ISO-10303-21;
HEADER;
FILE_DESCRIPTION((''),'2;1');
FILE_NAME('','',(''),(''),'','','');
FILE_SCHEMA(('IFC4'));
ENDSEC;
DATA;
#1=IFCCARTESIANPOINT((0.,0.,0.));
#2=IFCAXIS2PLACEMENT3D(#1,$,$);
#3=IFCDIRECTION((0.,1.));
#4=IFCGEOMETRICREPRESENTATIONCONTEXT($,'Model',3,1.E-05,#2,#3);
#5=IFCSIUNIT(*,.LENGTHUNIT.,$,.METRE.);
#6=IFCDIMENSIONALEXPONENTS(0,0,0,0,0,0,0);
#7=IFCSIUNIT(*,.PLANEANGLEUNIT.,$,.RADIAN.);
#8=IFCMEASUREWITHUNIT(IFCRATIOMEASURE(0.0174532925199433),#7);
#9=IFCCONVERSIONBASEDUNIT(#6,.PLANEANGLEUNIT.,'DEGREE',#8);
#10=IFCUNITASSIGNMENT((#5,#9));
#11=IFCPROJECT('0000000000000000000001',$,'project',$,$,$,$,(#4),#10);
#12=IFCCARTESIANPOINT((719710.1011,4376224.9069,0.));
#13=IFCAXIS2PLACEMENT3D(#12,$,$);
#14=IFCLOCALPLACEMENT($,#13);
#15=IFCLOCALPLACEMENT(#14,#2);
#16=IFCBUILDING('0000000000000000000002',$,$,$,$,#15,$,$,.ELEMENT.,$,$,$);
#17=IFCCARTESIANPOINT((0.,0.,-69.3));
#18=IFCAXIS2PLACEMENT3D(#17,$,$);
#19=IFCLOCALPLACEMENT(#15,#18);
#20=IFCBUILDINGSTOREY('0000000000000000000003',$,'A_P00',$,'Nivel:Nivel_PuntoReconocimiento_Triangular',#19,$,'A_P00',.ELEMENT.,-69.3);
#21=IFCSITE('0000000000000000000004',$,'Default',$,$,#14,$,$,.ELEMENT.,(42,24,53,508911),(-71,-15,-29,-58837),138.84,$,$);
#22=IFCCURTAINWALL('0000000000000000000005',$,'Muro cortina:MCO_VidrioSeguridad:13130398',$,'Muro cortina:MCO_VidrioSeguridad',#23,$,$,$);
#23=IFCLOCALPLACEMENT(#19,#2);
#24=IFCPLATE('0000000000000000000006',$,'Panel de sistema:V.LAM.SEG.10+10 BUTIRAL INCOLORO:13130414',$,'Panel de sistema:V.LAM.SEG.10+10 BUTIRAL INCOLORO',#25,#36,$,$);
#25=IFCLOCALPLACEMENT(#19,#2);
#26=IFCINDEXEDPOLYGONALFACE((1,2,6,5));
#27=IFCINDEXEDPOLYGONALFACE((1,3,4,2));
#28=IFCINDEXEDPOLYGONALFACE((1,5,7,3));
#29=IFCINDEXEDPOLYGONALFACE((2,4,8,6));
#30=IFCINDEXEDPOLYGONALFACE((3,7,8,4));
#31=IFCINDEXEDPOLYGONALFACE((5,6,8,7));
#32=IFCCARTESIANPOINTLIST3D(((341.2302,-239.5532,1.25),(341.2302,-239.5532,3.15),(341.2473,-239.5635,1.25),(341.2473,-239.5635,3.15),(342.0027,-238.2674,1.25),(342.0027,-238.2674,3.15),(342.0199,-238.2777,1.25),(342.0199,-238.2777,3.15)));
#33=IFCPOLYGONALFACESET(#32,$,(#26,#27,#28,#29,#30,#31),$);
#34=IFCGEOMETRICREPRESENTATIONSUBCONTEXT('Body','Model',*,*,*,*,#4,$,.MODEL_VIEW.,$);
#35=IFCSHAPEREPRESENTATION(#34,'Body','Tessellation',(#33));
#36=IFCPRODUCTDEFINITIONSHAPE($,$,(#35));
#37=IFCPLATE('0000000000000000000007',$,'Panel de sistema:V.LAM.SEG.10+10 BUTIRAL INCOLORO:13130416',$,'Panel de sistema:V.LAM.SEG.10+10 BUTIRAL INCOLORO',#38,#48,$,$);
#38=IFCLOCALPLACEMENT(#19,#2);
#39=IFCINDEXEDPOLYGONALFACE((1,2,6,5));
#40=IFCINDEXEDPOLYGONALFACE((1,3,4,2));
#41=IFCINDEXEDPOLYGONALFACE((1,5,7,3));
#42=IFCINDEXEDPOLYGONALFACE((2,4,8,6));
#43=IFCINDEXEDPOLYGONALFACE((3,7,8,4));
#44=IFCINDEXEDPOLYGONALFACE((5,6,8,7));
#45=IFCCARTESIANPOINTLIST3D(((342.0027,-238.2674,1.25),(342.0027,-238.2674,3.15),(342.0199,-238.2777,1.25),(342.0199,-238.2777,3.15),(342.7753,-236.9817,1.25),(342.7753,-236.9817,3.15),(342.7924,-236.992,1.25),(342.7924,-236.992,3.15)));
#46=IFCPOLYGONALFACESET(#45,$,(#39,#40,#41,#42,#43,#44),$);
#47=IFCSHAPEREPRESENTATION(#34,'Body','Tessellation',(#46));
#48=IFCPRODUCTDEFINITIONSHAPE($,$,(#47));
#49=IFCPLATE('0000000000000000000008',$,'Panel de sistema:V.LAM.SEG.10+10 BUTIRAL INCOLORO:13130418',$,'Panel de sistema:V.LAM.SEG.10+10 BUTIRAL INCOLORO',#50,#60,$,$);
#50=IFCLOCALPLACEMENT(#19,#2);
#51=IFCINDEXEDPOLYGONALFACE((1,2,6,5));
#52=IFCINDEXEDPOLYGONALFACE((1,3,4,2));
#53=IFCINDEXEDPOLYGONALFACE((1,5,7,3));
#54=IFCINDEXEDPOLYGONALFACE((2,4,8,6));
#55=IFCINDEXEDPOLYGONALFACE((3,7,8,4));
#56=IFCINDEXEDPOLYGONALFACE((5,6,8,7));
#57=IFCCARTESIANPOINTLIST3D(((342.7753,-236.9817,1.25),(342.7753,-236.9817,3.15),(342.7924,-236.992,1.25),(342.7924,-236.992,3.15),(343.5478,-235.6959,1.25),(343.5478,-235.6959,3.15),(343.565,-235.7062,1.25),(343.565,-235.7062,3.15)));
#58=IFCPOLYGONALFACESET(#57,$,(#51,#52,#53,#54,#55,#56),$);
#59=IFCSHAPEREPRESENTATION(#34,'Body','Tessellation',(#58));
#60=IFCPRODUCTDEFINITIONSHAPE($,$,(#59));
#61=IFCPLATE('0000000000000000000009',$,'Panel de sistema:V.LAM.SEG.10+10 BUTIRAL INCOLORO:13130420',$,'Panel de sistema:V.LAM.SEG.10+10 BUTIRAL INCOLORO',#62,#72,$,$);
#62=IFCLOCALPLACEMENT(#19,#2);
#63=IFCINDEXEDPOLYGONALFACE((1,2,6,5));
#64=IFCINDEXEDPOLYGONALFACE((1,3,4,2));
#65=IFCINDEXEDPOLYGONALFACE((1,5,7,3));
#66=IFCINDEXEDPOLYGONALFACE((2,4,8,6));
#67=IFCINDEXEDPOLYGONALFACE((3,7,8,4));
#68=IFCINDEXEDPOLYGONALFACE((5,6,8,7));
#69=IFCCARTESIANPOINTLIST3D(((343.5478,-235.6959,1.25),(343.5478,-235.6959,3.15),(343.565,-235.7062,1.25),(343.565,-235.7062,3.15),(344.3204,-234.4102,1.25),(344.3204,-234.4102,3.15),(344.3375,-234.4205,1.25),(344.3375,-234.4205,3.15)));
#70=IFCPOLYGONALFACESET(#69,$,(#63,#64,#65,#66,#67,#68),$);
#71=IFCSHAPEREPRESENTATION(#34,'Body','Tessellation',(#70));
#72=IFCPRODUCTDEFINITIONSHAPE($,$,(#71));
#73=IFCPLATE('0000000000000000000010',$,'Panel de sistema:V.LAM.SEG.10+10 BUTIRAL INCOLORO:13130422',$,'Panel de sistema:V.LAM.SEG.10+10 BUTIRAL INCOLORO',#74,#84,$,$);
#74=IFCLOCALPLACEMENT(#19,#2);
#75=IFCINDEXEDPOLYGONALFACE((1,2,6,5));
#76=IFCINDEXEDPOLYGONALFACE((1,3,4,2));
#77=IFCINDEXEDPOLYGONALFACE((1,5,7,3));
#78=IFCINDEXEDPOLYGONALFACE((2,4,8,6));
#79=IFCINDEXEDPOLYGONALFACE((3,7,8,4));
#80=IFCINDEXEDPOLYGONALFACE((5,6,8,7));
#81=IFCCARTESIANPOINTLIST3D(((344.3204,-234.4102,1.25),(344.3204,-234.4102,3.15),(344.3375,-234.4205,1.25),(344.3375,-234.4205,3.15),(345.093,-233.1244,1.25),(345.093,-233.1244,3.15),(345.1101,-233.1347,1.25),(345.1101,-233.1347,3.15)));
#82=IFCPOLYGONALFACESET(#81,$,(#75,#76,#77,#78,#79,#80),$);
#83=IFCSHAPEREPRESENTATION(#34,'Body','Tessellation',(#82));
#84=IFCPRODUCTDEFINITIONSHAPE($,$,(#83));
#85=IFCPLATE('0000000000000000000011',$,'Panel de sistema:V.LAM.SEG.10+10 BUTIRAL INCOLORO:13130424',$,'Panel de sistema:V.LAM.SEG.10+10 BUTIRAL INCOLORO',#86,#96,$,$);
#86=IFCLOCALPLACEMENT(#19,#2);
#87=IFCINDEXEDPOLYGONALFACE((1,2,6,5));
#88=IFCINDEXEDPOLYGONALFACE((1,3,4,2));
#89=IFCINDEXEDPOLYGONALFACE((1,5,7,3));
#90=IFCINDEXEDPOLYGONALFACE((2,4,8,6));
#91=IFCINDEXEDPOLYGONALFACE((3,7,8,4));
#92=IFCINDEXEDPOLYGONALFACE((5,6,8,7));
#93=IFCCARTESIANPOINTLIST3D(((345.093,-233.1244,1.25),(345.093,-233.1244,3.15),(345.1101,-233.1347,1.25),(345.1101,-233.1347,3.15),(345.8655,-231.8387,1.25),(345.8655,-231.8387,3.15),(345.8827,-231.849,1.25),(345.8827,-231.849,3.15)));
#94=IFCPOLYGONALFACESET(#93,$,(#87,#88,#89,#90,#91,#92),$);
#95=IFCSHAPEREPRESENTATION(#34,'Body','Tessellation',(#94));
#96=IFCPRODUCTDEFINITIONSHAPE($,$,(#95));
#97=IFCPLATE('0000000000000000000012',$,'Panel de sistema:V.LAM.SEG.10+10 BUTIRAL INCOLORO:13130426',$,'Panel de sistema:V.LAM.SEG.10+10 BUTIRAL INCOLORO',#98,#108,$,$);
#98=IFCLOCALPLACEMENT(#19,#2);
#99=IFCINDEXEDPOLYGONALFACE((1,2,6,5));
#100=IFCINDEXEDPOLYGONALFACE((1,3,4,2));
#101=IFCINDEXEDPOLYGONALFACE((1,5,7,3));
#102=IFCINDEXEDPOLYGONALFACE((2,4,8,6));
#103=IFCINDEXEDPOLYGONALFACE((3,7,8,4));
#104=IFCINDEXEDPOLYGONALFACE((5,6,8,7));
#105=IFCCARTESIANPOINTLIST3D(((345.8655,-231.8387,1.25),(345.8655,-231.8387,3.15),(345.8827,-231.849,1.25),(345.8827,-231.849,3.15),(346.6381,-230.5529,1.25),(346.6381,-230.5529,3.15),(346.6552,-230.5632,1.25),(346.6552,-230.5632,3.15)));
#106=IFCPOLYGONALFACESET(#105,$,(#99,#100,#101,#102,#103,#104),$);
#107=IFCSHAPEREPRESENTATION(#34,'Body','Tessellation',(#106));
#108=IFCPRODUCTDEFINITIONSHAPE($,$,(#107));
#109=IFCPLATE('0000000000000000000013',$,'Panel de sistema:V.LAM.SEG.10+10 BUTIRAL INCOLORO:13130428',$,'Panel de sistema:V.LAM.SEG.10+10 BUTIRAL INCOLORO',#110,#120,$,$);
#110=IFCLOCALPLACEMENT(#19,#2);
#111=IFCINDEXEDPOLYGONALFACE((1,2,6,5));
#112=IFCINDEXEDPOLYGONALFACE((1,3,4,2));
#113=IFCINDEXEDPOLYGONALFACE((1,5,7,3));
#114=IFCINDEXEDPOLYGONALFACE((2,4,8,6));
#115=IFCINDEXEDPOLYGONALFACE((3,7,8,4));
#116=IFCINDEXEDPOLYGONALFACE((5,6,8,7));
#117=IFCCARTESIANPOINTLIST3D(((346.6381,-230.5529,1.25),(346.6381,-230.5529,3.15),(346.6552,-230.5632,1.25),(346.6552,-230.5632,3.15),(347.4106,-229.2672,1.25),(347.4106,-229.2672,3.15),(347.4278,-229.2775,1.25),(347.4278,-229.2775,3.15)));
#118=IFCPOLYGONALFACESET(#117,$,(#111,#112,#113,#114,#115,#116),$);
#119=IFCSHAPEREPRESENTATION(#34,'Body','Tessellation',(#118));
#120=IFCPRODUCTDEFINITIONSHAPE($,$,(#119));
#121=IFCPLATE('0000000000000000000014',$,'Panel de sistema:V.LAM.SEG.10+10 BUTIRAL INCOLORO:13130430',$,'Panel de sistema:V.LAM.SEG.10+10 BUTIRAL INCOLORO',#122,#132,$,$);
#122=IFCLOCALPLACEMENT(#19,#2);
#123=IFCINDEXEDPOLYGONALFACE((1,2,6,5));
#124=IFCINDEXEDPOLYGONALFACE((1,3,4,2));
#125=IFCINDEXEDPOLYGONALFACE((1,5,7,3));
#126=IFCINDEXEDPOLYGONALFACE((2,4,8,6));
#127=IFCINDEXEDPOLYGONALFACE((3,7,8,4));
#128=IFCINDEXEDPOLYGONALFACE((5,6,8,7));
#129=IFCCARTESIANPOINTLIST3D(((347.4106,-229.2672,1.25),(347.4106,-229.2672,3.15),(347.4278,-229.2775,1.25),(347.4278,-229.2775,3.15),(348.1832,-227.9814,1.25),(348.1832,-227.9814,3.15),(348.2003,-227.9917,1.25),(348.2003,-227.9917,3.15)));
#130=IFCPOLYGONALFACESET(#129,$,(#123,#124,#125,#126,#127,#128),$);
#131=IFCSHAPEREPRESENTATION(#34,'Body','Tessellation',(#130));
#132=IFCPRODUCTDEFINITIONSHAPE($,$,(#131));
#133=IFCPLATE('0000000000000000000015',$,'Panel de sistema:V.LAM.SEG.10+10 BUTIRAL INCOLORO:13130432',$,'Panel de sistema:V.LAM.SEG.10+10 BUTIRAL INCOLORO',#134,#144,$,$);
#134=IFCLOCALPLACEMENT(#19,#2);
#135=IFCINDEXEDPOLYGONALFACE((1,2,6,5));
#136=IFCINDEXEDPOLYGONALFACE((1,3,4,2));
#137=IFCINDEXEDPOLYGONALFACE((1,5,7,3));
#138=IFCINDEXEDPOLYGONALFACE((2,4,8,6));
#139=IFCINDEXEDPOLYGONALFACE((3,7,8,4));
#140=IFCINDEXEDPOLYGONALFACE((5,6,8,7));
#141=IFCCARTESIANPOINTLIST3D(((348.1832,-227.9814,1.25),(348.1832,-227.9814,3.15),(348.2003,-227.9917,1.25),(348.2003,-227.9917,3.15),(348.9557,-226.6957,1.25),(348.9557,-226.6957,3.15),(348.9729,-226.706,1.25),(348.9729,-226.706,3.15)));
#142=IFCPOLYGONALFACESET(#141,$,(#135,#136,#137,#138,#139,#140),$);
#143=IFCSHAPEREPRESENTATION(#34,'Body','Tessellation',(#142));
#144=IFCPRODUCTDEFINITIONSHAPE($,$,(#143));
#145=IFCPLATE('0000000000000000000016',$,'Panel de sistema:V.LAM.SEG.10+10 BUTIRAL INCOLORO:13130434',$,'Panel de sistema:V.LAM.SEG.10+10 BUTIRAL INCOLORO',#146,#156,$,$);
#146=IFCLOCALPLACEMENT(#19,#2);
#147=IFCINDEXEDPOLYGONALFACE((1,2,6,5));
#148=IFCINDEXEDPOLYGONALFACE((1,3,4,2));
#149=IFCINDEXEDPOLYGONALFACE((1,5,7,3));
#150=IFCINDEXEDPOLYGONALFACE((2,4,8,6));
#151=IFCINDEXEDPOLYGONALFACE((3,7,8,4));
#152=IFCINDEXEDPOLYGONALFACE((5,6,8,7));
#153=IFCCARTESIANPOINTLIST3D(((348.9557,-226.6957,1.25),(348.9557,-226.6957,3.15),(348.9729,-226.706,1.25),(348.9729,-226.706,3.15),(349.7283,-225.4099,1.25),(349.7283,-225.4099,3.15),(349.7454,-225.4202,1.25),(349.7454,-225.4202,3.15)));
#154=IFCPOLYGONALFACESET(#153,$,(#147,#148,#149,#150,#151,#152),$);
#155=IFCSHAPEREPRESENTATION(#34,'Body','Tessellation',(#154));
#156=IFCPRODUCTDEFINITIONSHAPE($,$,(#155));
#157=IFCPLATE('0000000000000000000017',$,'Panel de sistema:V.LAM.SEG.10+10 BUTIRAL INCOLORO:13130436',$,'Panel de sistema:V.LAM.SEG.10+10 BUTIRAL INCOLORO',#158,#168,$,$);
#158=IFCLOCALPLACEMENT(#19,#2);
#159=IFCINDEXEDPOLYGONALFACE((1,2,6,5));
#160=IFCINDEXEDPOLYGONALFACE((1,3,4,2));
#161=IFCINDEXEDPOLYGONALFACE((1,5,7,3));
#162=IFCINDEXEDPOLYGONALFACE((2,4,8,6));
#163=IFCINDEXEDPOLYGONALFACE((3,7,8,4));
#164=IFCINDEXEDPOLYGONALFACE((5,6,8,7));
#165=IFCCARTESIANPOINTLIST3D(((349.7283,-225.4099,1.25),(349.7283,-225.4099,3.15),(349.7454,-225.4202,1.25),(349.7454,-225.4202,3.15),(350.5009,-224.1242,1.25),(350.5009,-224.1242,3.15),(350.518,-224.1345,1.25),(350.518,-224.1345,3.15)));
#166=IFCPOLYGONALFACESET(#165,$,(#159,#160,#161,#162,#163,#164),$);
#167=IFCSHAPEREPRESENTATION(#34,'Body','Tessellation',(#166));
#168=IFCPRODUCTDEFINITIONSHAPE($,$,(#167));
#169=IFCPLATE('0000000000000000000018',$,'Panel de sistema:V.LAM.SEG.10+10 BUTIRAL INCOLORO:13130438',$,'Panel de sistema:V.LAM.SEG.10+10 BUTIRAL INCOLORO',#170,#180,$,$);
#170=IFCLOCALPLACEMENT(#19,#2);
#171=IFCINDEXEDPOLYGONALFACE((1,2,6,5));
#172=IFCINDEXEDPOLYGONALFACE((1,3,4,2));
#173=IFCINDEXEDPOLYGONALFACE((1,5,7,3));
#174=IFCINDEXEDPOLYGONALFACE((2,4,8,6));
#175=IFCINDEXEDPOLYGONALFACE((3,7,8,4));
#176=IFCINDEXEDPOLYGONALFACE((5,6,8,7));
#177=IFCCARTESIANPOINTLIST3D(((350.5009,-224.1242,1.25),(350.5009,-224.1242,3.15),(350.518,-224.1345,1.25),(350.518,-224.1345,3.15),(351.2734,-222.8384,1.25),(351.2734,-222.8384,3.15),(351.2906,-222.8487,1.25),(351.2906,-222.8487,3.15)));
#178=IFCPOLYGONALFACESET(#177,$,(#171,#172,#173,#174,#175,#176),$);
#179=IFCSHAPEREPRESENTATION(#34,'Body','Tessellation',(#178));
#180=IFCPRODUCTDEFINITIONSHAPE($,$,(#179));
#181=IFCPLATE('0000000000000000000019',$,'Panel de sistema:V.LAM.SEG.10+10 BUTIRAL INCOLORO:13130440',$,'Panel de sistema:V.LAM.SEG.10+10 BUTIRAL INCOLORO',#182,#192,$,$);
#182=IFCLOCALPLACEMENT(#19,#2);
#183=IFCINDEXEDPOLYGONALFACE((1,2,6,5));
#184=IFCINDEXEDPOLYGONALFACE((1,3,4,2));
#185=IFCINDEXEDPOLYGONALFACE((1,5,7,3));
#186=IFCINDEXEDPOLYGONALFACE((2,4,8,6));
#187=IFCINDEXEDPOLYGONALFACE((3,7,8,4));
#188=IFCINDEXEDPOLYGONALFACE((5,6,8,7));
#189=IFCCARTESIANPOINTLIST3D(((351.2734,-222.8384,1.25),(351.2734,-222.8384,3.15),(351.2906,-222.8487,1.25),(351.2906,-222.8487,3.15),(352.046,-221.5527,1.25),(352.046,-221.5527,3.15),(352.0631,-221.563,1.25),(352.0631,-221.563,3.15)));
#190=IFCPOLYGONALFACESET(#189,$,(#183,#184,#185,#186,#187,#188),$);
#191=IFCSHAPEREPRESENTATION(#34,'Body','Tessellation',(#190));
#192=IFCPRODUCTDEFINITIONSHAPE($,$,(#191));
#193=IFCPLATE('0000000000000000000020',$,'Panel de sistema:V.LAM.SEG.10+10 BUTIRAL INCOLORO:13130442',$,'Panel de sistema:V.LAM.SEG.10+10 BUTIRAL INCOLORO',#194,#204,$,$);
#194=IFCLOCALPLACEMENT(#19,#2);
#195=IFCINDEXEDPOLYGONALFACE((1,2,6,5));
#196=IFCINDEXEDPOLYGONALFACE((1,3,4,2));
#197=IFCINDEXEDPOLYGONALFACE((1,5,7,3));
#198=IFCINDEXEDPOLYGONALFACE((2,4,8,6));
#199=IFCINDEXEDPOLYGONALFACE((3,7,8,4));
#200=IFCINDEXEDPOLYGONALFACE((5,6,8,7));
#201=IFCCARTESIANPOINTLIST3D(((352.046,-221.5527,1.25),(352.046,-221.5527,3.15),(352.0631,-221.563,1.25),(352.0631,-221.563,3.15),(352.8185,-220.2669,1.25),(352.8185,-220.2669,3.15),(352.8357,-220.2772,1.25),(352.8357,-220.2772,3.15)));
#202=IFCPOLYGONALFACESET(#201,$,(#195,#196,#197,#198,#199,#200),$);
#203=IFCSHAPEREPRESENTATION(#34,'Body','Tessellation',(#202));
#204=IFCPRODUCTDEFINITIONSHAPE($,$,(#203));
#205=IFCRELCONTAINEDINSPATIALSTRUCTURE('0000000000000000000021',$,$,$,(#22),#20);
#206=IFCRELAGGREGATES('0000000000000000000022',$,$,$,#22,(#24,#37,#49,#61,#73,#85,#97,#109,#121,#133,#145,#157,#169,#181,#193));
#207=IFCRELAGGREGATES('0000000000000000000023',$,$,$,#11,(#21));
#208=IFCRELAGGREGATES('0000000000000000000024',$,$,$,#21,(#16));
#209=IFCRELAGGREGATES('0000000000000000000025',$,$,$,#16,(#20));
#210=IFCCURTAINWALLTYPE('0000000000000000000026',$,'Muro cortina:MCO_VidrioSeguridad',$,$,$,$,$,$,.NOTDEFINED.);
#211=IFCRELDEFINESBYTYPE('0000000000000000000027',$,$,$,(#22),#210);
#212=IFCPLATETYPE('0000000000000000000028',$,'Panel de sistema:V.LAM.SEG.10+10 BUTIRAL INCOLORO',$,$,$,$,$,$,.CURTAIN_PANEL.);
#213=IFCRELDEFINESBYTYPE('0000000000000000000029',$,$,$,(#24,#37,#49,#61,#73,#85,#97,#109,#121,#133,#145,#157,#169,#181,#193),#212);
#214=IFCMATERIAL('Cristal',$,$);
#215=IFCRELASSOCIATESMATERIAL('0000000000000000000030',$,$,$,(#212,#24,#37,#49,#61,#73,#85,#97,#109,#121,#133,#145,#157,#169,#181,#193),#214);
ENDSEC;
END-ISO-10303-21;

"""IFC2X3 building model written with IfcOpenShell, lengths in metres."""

from ifc_helpers import new_model, entity, si_unit, converted_unit, direction, frame, origin, origin_2d_with_axis, place, context, subcontext, project, spatial, rectangle, extrude, source, transform, mapped, material, type_object, type_shapes, element, aggregate, save


model = new_model("IFC2X3")

# Units and contexts
model_context = context("Model", 3, precision=1e-05, world=origin(), true_north=direction((0.0, 1.0)))
body_context = subcontext(model_context, "Body", "Model", "MODEL_VIEW")
ifc_project = project(units=[si_unit("LENGTHUNIT", "METRE"), converted_unit("PLANEANGLEUNIT", "DEGREE", entity("IfcRatioMeasure", 0.0174532925199433), si_unit("PLANEANGLEUNIT", "RADIAN"), dimensions=[0, 0, 0, 0, 0, 0, 0])], contexts=[model_context])

# Site, building, storey
site_placement = place(None, frame((719710.1011, 4376224.9069, 0.0)))
site = spatial("IfcSite", under=ifc_project, at=site_placement, Name="Default", CompositionType="ELEMENT", RefLatitude=(42, 24, 53, 508911), RefLongitude=(-71, -15, -29, -58837), RefElevation=138.84)
building_placement = place(site_placement, origin())
building = spatial("IfcBuilding", under=site, at=building_placement, CompositionType="ELEMENT")
storey_placement = place(building_placement, frame((0.0, 0.0, -69.3)))
storey = spatial("IfcBuildingStorey", under=building, at=storey_placement, Name="A_P00", ObjectType="Nivel:Nivel_PuntoReconocimiento_Triangular", LongName="A_P00", CompositionType="ELEMENT", Elevation=-69.3)

# Curtain wall, plates
curtain_wall_type = type_object("IfcCurtainWallType", Name="Muro cortina:MCO_VidrioSeguridad", PredefinedType="NOTDEFINED")
curtain_wall_placement = place(storey_placement, frame((0.0, 0.0, 69.3)))
curtain_wall = element("IfcCurtainWall", 1, at=curtain_wall_placement, inside=storey, type_object=curtain_wall_type, Name="Muro cortina:MCO_VidrioSeguridad:13130398", ObjectType="Muro cortina:MCO_VidrioSeguridad")
ifc_material_1 = material(Name="Cristal")
plate_type = type_object("IfcPlateType", Name="Panel de sistema:V.LAM.SEG.10+10 BUTIRAL INCOLORO", PredefinedType="CURTAIN_PANEL", material=ifc_material_1)
shared_shape = source(origin(), body_context, "Body", "SweptSolid", [
    extrude(rectangle(XDim=0.02, YDim=1.5, at=origin_2d_with_axis()), frame((0.0, 0.0, 0.0), z_axis=(0.0, 0.0, 1.0), x_axis=(0.0, 1.0, 0.0)), (0.0, 0.0, 1.0), 1.9),
])
type_shapes(plate_type, [shared_shape])
plate_1_placement = place(curtain_wall_placement, frame((341.625, -238.9155, -68.05), z_axis=(0.0, 0.0, 1.0), x_axis=(0.515038, 0.857167, 0.0)))
plate_1 = element("IfcPlate", 2, at=plate_1_placement, type_object=plate_type, material=ifc_material_1, Name="Panel de sistema:V.LAM.SEG.10+10 BUTIRAL INCOLORO:13130414", ObjectType="Panel de sistema:V.LAM.SEG.10+10 BUTIRAL INCOLORO", context=body_context, shape_type="MappedRepresentation", body=[
    mapped(shared_shape, transform((0.0, 0.0, 0.0), scale=1.0)),
])
plate_2_placement = place(curtain_wall_placement, frame((342.3976, -237.6297, -68.05), z_axis=(0.0, 0.0, 1.0), x_axis=(0.515038, 0.857167, 0.0)))
plate_2 = element("IfcPlate", 3, at=plate_2_placement, type_object=plate_type, material=ifc_material_1, Name="Panel de sistema:V.LAM.SEG.10+10 BUTIRAL INCOLORO:13130416", ObjectType="Panel de sistema:V.LAM.SEG.10+10 BUTIRAL INCOLORO", context=body_context, shape_type="MappedRepresentation", body=[
    mapped(shared_shape, transform((0.0, 0.0, 0.0), scale=1.0)),
])
plate_3_placement = place(curtain_wall_placement, frame((343.1701, -236.344, -68.05), z_axis=(0.0, 0.0, 1.0), x_axis=(0.515038, 0.857167, 0.0)))
plate_3 = element("IfcPlate", 4, at=plate_3_placement, type_object=plate_type, material=ifc_material_1, Name="Panel de sistema:V.LAM.SEG.10+10 BUTIRAL INCOLORO:13130418", ObjectType="Panel de sistema:V.LAM.SEG.10+10 BUTIRAL INCOLORO", context=body_context, shape_type="MappedRepresentation", body=[
    mapped(shared_shape, transform((0.0, 0.0, 0.0), scale=1.0)),
])
plate_4_placement = place(curtain_wall_placement, frame((343.9427, -235.0582, -68.05), z_axis=(0.0, 0.0, 1.0), x_axis=(0.515038, 0.857167, 0.0)))
plate_4 = element("IfcPlate", 5, at=plate_4_placement, type_object=plate_type, material=ifc_material_1, Name="Panel de sistema:V.LAM.SEG.10+10 BUTIRAL INCOLORO:13130420", ObjectType="Panel de sistema:V.LAM.SEG.10+10 BUTIRAL INCOLORO", context=body_context, shape_type="MappedRepresentation", body=[
    mapped(shared_shape, transform((0.0, 0.0, 0.0), scale=1.0)),
])
plate_5_placement = place(curtain_wall_placement, frame((344.7153, -233.7725, -68.05), z_axis=(0.0, 0.0, 1.0), x_axis=(0.515038, 0.857167, 0.0)))
plate_5 = element("IfcPlate", 6, at=plate_5_placement, type_object=plate_type, material=ifc_material_1, Name="Panel de sistema:V.LAM.SEG.10+10 BUTIRAL INCOLORO:13130422", ObjectType="Panel de sistema:V.LAM.SEG.10+10 BUTIRAL INCOLORO", context=body_context, shape_type="MappedRepresentation", body=[
    mapped(shared_shape, transform((0.0, 0.0, 0.0), scale=1.0)),
])
plate_6_placement = place(curtain_wall_placement, frame((345.4878, -232.4867, -68.05), z_axis=(0.0, 0.0, 1.0), x_axis=(0.515038, 0.857167, 0.0)))
plate_6 = element("IfcPlate", 7, at=plate_6_placement, type_object=plate_type, material=ifc_material_1, Name="Panel de sistema:V.LAM.SEG.10+10 BUTIRAL INCOLORO:13130424", ObjectType="Panel de sistema:V.LAM.SEG.10+10 BUTIRAL INCOLORO", context=body_context, shape_type="MappedRepresentation", body=[
    mapped(shared_shape, transform((0.0, 0.0, 0.0), scale=1.0)),
])
plate_7_placement = place(curtain_wall_placement, frame((346.2604, -231.2009, -68.05), z_axis=(0.0, 0.0, 1.0), x_axis=(0.515038, 0.857167, 0.0)))
plate_7 = element("IfcPlate", 8, at=plate_7_placement, type_object=plate_type, material=ifc_material_1, Name="Panel de sistema:V.LAM.SEG.10+10 BUTIRAL INCOLORO:13130426", ObjectType="Panel de sistema:V.LAM.SEG.10+10 BUTIRAL INCOLORO", context=body_context, shape_type="MappedRepresentation", body=[
    mapped(shared_shape, transform((0.0, 0.0, 0.0), scale=1.0)),
])
plate_8_placement = place(curtain_wall_placement, frame((347.0329, -229.9152, -68.05), z_axis=(0.0, 0.0, 1.0), x_axis=(0.515038, 0.857167, 0.0)))
plate_8 = element("IfcPlate", 9, at=plate_8_placement, type_object=plate_type, material=ifc_material_1, Name="Panel de sistema:V.LAM.SEG.10+10 BUTIRAL INCOLORO:13130428", ObjectType="Panel de sistema:V.LAM.SEG.10+10 BUTIRAL INCOLORO", context=body_context, shape_type="MappedRepresentation", body=[
    mapped(shared_shape, transform((0.0, 0.0, 0.0), scale=1.0)),
])
plate_9_placement = place(curtain_wall_placement, frame((347.8055, -228.6294, -68.05), z_axis=(0.0, 0.0, 1.0), x_axis=(0.515038, 0.857167, 0.0)))
plate_9 = element("IfcPlate", 10, at=plate_9_placement, type_object=plate_type, material=ifc_material_1, Name="Panel de sistema:V.LAM.SEG.10+10 BUTIRAL INCOLORO:13130430", ObjectType="Panel de sistema:V.LAM.SEG.10+10 BUTIRAL INCOLORO", context=body_context, shape_type="MappedRepresentation", body=[
    mapped(shared_shape, transform((0.0, 0.0, 0.0), scale=1.0)),
])
plate_10_placement = place(curtain_wall_placement, frame((348.578, -227.3437, -68.05), z_axis=(0.0, 0.0, 1.0), x_axis=(0.515038, 0.857167, 0.0)))
plate_10 = element("IfcPlate", 11, at=plate_10_placement, type_object=plate_type, material=ifc_material_1, Name="Panel de sistema:V.LAM.SEG.10+10 BUTIRAL INCOLORO:13130432", ObjectType="Panel de sistema:V.LAM.SEG.10+10 BUTIRAL INCOLORO", context=body_context, shape_type="MappedRepresentation", body=[
    mapped(shared_shape, transform((0.0, 0.0, 0.0), scale=1.0)),
])
plate_11_placement = place(curtain_wall_placement, frame((349.3506, -226.0579, -68.05), z_axis=(0.0, 0.0, 1.0), x_axis=(0.515038, 0.857167, 0.0)))
plate_11 = element("IfcPlate", 12, at=plate_11_placement, type_object=plate_type, material=ifc_material_1, Name="Panel de sistema:V.LAM.SEG.10+10 BUTIRAL INCOLORO:13130434", ObjectType="Panel de sistema:V.LAM.SEG.10+10 BUTIRAL INCOLORO", context=body_context, shape_type="MappedRepresentation", body=[
    mapped(shared_shape, transform((0.0, 0.0, 0.0), scale=1.0)),
])
plate_12_placement = place(curtain_wall_placement, frame((350.1232, -224.7722, -68.05), z_axis=(0.0, 0.0, 1.0), x_axis=(0.515038, 0.857167, 0.0)))
plate_12 = element("IfcPlate", 13, at=plate_12_placement, type_object=plate_type, material=ifc_material_1, Name="Panel de sistema:V.LAM.SEG.10+10 BUTIRAL INCOLORO:13130436", ObjectType="Panel de sistema:V.LAM.SEG.10+10 BUTIRAL INCOLORO", context=body_context, shape_type="MappedRepresentation", body=[
    mapped(shared_shape, transform((0.0, 0.0, 0.0), scale=1.0)),
])
plate_13_placement = place(curtain_wall_placement, frame((350.8957, -223.4864, -68.05), z_axis=(0.0, 0.0, 1.0), x_axis=(0.515038, 0.857167, 0.0)))
plate_13 = element("IfcPlate", 14, at=plate_13_placement, type_object=plate_type, material=ifc_material_1, Name="Panel de sistema:V.LAM.SEG.10+10 BUTIRAL INCOLORO:13130438", ObjectType="Panel de sistema:V.LAM.SEG.10+10 BUTIRAL INCOLORO", context=body_context, shape_type="MappedRepresentation", body=[
    mapped(shared_shape, transform((0.0, 0.0, 0.0), scale=1.0)),
])
plate_14_placement = place(curtain_wall_placement, frame((351.6683, -222.2007, -68.05), z_axis=(0.0, 0.0, 1.0), x_axis=(0.515038, 0.857167, 0.0)))
plate_14 = element("IfcPlate", 15, at=plate_14_placement, type_object=plate_type, material=ifc_material_1, Name="Panel de sistema:V.LAM.SEG.10+10 BUTIRAL INCOLORO:13130440", ObjectType="Panel de sistema:V.LAM.SEG.10+10 BUTIRAL INCOLORO", context=body_context, shape_type="MappedRepresentation", body=[
    mapped(shared_shape, transform((0.0, 0.0, 0.0), scale=1.0)),
])
plate_15_placement = place(curtain_wall_placement, frame((352.4408, -220.9149, -68.05), z_axis=(0.0, 0.0, 1.0), x_axis=(0.515038, 0.857167, 0.0)))
plate_15 = element("IfcPlate", 16, at=plate_15_placement, type_object=plate_type, material=ifc_material_1, Name="Panel de sistema:V.LAM.SEG.10+10 BUTIRAL INCOLORO:13130442", ObjectType="Panel de sistema:V.LAM.SEG.10+10 BUTIRAL INCOLORO", context=body_context, shape_type="MappedRepresentation", body=[
    mapped(shared_shape, transform((0.0, 0.0, 0.0), scale=1.0)),
])
aggregate(curtain_wall, [plate_1, plate_2, plate_3, plate_4, plate_5, plate_6, plate_7, plate_8, plate_9, plate_10, plate_11, plate_12, plate_13, plate_14, plate_15])

save(model, "model.ifc")
